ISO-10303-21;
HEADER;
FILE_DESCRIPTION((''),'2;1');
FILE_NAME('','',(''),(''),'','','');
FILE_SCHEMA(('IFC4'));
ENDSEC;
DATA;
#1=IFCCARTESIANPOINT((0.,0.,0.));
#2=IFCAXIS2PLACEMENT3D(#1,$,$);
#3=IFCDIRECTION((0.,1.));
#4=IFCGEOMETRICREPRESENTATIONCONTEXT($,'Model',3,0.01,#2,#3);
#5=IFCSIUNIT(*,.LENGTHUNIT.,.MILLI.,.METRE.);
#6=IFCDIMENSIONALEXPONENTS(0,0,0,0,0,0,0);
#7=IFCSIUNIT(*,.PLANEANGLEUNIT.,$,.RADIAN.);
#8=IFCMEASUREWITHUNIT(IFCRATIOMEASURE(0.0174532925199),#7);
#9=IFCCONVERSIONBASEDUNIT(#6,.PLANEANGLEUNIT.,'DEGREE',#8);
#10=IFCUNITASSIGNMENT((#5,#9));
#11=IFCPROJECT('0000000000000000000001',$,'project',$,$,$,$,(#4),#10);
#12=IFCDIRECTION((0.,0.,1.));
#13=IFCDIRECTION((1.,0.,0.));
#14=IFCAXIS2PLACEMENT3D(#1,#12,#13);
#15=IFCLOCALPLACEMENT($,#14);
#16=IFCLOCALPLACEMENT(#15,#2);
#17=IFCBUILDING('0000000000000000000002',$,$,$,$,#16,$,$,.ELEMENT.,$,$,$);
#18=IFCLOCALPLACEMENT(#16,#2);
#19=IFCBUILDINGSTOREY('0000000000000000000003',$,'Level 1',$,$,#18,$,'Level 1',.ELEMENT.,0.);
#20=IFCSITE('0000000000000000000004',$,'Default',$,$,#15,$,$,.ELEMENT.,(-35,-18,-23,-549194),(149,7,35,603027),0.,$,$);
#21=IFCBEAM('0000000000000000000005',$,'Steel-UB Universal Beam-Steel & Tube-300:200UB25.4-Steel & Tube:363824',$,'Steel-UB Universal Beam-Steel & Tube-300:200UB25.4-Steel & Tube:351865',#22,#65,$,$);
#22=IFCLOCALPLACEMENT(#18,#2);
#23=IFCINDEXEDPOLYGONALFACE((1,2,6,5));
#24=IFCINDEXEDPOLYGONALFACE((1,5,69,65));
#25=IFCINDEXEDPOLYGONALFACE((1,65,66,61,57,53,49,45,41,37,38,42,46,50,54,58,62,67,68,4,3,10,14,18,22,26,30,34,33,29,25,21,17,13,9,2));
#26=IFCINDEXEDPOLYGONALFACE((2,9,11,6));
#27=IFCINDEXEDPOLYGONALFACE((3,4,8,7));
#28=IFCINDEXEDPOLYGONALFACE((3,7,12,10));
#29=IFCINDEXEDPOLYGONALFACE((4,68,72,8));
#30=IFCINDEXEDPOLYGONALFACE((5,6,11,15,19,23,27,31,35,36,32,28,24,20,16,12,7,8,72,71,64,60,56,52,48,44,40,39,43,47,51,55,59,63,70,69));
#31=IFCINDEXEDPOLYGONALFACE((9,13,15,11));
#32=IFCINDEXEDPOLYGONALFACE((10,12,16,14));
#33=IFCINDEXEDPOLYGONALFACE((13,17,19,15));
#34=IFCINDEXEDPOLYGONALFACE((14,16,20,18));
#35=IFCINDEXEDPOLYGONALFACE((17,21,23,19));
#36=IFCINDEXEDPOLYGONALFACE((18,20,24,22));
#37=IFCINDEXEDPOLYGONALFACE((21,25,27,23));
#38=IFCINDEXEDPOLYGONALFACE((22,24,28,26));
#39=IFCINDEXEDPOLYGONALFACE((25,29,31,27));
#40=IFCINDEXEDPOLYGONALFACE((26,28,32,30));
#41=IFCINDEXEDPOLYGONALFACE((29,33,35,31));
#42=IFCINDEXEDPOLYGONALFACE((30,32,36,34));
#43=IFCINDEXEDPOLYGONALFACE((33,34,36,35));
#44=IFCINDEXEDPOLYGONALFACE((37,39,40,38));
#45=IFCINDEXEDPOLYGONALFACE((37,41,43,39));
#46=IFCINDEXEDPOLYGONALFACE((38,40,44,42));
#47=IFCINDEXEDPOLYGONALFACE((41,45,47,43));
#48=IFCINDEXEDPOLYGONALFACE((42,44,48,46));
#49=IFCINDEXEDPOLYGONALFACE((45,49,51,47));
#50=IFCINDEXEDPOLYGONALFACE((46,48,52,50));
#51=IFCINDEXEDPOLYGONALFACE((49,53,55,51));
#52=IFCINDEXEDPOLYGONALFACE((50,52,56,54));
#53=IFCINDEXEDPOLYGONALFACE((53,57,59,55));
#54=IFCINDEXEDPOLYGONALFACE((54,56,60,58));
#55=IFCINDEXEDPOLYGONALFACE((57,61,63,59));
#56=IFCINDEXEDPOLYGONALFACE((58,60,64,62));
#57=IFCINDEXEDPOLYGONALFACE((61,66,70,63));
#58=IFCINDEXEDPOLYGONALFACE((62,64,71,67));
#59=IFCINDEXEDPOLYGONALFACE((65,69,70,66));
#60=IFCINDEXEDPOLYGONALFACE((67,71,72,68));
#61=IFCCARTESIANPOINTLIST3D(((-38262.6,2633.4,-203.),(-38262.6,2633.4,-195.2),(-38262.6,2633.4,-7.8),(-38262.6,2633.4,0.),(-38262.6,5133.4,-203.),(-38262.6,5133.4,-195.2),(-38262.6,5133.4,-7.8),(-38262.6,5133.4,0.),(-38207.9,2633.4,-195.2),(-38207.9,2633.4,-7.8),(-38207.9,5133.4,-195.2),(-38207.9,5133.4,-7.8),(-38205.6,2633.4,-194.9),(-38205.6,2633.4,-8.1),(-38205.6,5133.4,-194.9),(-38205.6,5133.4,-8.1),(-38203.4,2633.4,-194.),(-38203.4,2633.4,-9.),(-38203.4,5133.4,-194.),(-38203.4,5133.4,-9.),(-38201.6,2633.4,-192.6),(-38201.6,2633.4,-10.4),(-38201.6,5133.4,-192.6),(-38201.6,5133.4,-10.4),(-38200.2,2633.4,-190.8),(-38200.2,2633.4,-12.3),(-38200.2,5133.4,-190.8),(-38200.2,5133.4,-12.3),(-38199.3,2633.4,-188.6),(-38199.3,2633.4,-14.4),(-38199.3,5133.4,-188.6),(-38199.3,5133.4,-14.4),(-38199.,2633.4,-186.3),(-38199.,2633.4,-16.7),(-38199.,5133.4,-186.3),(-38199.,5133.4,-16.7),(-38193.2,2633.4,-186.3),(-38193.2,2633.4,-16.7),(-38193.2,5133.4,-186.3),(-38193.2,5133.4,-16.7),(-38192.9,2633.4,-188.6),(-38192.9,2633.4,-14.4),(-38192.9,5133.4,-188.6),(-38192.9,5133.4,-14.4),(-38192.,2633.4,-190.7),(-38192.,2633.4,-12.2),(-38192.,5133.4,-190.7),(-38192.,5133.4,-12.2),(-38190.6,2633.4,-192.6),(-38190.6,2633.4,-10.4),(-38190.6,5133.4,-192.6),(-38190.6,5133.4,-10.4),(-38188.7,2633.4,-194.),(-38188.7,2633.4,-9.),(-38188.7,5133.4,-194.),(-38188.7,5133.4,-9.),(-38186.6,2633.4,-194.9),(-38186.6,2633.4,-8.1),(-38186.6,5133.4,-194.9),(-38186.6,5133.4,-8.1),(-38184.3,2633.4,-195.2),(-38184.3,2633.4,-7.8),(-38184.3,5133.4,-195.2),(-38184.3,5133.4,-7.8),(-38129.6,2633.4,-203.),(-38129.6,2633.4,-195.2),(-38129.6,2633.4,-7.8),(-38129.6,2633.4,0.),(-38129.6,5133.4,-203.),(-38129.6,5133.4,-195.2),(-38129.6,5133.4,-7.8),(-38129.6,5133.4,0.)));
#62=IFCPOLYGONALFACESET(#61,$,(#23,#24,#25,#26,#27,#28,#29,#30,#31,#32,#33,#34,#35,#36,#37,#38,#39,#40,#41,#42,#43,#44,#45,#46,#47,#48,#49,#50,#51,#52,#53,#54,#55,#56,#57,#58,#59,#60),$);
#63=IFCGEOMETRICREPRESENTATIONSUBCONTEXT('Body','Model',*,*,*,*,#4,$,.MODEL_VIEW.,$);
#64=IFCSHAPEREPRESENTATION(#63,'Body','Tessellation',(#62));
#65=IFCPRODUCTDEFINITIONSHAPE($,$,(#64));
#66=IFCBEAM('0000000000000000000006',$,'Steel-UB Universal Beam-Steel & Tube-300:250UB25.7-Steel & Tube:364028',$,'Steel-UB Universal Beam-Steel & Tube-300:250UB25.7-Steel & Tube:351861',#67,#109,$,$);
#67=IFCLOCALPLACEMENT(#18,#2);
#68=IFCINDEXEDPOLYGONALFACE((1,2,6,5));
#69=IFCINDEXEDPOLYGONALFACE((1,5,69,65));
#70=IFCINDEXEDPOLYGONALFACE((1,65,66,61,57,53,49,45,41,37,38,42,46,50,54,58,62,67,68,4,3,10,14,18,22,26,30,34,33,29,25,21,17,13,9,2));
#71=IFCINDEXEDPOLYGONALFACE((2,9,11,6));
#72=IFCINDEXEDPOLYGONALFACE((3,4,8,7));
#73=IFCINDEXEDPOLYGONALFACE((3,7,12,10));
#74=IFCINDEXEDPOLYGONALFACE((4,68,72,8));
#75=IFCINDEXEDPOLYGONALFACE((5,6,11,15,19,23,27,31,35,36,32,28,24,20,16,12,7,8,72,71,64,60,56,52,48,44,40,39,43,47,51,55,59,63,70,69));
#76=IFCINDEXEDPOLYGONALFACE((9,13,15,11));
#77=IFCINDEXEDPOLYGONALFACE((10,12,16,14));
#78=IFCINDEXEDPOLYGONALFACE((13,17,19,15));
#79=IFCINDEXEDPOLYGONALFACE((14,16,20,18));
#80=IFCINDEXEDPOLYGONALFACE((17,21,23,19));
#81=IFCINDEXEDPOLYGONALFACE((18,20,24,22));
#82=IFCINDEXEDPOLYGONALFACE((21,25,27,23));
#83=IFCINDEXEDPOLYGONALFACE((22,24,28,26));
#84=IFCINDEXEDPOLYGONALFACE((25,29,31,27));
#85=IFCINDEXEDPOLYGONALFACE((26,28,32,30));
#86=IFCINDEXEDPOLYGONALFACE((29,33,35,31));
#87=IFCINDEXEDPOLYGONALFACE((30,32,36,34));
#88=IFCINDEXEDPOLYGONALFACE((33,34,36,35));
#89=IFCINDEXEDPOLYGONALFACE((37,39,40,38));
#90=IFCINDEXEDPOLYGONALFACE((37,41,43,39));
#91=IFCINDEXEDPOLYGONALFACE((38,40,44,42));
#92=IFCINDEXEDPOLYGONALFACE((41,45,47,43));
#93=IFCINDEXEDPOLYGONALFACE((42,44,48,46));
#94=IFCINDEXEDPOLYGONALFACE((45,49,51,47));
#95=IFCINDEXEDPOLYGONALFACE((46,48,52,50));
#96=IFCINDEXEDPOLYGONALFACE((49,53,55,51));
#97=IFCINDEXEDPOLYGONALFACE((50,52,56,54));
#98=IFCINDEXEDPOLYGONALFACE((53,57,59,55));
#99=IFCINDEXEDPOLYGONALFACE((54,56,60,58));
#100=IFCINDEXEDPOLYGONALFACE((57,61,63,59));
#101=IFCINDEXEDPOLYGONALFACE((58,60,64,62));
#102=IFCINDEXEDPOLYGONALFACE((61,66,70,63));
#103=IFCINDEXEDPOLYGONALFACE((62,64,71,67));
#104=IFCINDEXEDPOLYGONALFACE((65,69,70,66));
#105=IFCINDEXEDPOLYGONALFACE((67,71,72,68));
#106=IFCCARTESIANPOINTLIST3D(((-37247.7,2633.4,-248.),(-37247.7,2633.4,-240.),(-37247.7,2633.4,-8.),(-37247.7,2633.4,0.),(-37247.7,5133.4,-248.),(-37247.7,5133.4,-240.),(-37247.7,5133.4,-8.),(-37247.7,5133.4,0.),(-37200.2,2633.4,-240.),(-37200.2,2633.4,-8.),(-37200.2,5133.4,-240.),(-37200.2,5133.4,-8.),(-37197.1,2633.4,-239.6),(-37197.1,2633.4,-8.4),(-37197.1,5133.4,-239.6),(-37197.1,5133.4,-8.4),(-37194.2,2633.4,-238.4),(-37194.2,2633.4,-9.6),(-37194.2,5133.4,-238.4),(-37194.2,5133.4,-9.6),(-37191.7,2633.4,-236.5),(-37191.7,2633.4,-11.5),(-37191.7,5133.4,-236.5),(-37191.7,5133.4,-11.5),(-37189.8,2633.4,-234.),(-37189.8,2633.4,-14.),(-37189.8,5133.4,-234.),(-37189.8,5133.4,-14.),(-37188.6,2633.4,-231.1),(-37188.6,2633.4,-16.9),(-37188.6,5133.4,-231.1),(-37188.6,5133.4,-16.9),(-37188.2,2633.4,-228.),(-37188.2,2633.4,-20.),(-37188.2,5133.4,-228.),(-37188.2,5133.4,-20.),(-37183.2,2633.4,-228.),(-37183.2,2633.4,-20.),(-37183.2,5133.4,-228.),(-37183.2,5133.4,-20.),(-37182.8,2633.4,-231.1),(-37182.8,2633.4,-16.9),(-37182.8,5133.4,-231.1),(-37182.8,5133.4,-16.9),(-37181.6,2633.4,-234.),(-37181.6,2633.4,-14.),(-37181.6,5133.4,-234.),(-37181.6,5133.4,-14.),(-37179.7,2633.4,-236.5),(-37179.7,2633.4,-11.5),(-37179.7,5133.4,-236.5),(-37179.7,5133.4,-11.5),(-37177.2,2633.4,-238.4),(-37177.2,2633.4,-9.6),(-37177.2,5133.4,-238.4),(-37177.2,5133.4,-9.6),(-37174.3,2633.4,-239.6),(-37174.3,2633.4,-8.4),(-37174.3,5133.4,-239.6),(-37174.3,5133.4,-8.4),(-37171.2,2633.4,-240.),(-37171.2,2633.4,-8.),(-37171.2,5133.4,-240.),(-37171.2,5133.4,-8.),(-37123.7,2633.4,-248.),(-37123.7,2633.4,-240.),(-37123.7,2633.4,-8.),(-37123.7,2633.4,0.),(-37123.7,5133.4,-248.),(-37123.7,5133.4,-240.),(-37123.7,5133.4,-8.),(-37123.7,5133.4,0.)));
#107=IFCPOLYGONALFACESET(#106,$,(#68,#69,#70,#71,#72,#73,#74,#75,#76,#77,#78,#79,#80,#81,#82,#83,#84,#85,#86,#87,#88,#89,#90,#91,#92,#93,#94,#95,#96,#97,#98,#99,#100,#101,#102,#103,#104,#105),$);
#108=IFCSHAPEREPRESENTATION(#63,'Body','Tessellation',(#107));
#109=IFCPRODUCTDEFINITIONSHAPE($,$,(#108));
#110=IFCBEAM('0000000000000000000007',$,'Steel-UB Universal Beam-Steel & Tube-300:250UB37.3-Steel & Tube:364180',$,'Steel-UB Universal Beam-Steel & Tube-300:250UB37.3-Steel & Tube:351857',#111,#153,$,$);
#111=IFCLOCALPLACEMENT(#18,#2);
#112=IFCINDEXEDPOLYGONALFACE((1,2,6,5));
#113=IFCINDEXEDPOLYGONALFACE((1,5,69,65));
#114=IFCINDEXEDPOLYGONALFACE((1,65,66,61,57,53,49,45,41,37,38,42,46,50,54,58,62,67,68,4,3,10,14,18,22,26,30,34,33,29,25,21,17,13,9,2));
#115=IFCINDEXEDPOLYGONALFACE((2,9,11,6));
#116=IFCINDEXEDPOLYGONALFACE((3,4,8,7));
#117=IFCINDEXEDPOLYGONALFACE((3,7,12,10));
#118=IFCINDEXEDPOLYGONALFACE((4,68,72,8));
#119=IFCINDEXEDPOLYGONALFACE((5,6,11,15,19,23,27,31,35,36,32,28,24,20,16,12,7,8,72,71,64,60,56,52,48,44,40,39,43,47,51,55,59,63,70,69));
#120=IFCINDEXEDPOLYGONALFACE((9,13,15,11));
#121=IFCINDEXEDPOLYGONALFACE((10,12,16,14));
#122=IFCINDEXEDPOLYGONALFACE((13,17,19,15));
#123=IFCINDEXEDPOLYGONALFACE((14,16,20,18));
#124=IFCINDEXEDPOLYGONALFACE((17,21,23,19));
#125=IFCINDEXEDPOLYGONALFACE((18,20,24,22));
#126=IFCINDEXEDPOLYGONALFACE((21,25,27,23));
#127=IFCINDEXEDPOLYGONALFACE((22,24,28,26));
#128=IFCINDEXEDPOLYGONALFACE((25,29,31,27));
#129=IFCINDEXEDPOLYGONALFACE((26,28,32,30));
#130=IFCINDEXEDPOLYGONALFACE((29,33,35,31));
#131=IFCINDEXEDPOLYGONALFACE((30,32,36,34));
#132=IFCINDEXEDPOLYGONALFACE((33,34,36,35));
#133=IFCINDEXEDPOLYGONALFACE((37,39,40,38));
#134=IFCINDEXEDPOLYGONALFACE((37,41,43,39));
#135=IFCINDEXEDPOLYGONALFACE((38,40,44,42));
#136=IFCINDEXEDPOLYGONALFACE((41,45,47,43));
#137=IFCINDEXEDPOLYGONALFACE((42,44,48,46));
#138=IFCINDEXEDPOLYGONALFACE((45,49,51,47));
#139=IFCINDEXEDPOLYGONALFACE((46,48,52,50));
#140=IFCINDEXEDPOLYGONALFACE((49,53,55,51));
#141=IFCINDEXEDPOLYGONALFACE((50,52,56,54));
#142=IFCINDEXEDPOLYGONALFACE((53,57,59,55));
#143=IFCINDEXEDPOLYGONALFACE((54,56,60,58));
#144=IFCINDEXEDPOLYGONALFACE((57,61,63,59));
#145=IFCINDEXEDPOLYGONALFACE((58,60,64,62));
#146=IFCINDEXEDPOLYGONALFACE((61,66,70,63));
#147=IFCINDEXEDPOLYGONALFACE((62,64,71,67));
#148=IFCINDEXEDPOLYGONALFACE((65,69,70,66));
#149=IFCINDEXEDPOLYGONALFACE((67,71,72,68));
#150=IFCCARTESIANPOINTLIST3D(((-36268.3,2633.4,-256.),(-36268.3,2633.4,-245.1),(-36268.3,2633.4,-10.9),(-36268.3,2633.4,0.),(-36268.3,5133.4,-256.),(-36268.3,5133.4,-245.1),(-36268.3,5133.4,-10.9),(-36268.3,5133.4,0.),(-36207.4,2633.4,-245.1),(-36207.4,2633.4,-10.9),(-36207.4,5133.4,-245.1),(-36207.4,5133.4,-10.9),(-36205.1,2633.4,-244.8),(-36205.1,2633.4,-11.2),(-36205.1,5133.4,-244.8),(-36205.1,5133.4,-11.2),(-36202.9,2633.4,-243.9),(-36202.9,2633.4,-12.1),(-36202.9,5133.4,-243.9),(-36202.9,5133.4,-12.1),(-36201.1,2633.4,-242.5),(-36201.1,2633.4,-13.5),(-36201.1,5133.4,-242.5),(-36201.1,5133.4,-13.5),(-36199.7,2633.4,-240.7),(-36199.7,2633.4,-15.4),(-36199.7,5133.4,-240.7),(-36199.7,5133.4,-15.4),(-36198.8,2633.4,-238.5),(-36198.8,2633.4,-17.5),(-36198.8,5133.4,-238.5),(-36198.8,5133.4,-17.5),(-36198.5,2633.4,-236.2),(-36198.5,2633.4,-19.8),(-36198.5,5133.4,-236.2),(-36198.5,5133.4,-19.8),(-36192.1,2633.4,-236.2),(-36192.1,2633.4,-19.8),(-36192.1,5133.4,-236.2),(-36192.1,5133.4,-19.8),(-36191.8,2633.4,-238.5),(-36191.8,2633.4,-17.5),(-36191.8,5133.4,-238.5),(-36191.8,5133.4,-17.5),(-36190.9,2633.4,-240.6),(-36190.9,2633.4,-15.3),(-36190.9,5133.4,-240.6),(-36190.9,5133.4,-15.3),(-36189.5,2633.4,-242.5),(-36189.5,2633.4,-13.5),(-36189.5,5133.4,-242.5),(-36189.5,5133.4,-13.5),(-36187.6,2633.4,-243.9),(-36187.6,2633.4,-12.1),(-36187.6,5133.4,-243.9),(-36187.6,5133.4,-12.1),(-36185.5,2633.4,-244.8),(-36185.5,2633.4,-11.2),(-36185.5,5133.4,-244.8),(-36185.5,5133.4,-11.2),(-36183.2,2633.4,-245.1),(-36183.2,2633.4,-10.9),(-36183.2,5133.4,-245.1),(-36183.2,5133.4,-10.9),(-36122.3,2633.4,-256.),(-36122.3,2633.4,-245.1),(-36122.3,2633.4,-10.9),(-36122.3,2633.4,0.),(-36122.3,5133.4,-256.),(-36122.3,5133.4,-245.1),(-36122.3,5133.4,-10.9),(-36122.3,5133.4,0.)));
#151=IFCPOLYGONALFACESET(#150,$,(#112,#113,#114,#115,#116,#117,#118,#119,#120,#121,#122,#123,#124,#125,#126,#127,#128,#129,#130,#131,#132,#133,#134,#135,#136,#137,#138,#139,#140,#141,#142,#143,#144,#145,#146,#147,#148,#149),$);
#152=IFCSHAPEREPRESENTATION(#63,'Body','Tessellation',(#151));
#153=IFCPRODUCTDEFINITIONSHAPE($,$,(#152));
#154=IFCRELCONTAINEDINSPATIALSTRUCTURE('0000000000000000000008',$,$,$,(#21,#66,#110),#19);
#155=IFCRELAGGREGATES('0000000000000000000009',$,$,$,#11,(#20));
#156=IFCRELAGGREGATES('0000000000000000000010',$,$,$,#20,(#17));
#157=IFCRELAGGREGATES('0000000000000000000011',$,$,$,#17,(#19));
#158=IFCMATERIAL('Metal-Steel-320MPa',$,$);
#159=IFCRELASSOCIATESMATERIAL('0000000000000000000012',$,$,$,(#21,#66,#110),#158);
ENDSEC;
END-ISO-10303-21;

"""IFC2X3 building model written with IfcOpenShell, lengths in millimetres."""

from ifc_helpers import new_model, entity, si_unit, converted_unit, direction, frame, frame_2d, origin, origin_with_axes, place, context, subcontext, project, spatial, polyline, circle_curve, parameter, trimmed, segment, composite_curve, outline, extrude, material, element, save


model = new_model("IFC2X3")

# Units and contexts
model_context = context("Model", 3, precision=0.01, world=origin(), true_north=direction((0.0, 1.0)))
body_context = subcontext(model_context, "Body", "Model", "MODEL_VIEW")
ifc_project = project(units=[si_unit("LENGTHUNIT", "METRE", prefix="MILLI"), converted_unit("PLANEANGLEUNIT", "DEGREE", entity("IfcRatioMeasure", 0.0174532925199), si_unit("PLANEANGLEUNIT", "RADIAN"), dimensions=[0, 0, 0, 0, 0, 0, 0])], contexts=[model_context])

# Site, building, storey
site_placement = place(None, origin_with_axes())
site = spatial("IfcSite", under=ifc_project, at=site_placement, Name="Default", CompositionType="ELEMENT", RefLatitude=(-35, -18, -23, -549194), RefLongitude=(149, 7, 35, 603027), RefElevation=0.0)
building_placement = place(site_placement, origin())
building = spatial("IfcBuilding", under=site, at=building_placement, CompositionType="ELEMENT")
storey_placement = place(building_placement, origin())
storey = spatial("IfcBuildingStorey", under=building, at=storey_placement, Name="Level 1", LongName="Level 1", CompositionType="ELEMENT", Elevation=0.0)

# Beams
ifc_material = material(Name="Metal-Steel-320MPa")
beam_1_placement = place(storey_placement, frame((-38196.1, 5133.4, 0.0), z_axis=(0.0, 0.0, 1.0), x_axis=(0.0, -1.0, 0.0)))
element("IfcBeam", 1, at=beam_1_placement, inside=storey, material=ifc_material, Name="Steel-UB Universal Beam-Steel & Tube-300:200UB25.4-Steel & Tube:363824", ObjectType="Steel-UB Universal Beam-Steel & Tube-300:200UB25.4-Steel & Tube:351865", context=body_context, shape_type="SweptSolid", body=[
    extrude(outline(composite_curve([segment(polyline([(93.7, -66.5), (101.5, -66.5)]), True, "CONTINUOUS"), segment(polyline([(101.5, -66.5), (101.5, 66.5)]), True, "CONTINUOUS"), segment(polyline([(101.5, 66.5), (93.7, 66.5)]), True, "CONTINUOUS"), segment(polyline([(93.7, 66.5), (93.7, 11.8)]), True, "CONTINUOUS"), segment(trimmed(circle_curve(frame_2d((84.8, 11.8), x_axis=(1.0, 0.0)), 8.9), [parameter(270.0)], [parameter(0.0)], True, "PARAMETER"), False, "CONTINUOUS"), segment(polyline([(84.8, 2.9), (-84.8, 2.9)]), True, "CONTINUOUS"), segment(trimmed(circle_curve(frame_2d((-84.8, 11.8), x_axis=(0.0, -1.0)), 8.9), [parameter(270.0)], [parameter(0.0)], True, "PARAMETER"), False, "CONTINUOUS"), segment(polyline([(-93.7, 11.8), (-93.7, 66.5)]), True, "CONTINUOUS"), segment(polyline([(-93.7, 66.5), (-101.5, 66.5)]), True, "CONTINUOUS"), segment(polyline([(-101.5, 66.5), (-101.5, -66.5)]), True, "CONTINUOUS"), segment(polyline([(-101.5, -66.5), (-93.7, -66.5)]), True, "CONTINUOUS"), segment(polyline([(-93.7, -66.5), (-93.7, -11.8)]), True, "CONTINUOUS"), segment(trimmed(circle_curve(frame_2d((-84.8, -11.8), x_axis=(-1.0, 0.0)), 8.9), [parameter(270.0)], [parameter(0.0)], True, "PARAMETER"), False, "CONTINUOUS"), segment(polyline([(-84.8, -2.9), (84.8, -2.9)]), True, "CONTINUOUS"), segment(trimmed(circle_curve(frame_2d((84.8, -11.8), x_axis=(0.0, 1.0)), 8.9), [parameter(270.0)], [parameter(0.0)], True, "PARAMETER"), False, "CONTINUOUS"), segment(polyline([(93.7, -11.8), (93.7, -66.5)]), True, "CONTINUOUS")], self_intersect=False)), frame((0.0, 0.0, -101.5), z_axis=(1.0, 0.0, 0.0), x_axis=(0.0, 0.0, -1.0)), (0.0, 0.0, 1.0), 2500.0),
])
beam_2_placement = place(storey_placement, frame((-37185.7, 5133.4, 0.0), z_axis=(0.0, 0.0, 1.0), x_axis=(0.0, -1.0, 0.0)))
element("IfcBeam", 2, at=beam_2_placement, inside=storey, material=ifc_material, Name="Steel-UB Universal Beam-Steel & Tube-300:250UB25.7-Steel & Tube:364028", ObjectType="Steel-UB Universal Beam-Steel & Tube-300:250UB25.7-Steel & Tube:351861", context=body_context, shape_type="SweptSolid", body=[
    extrude(outline(composite_curve([segment(polyline([(116.0, -62.0), (124.0, -62.0)]), True, "CONTINUOUS"), segment(polyline([(124.0, -62.0), (124.0, 62.0)]), True, "CONTINUOUS"), segment(polyline([(124.0, 62.0), (116.0, 62.0)]), True, "CONTINUOUS"), segment(polyline([(116.0, 62.0), (116.0, 14.5)]), True, "CONTINUOUS"), segment(trimmed(circle_curve(frame_2d((104.0, 14.5), x_axis=(1.0, 0.0)), 12.0), [parameter(270.0)], [parameter(0.0)], True, "PARAMETER"), False, "CONTINUOUS"), segment(polyline([(104.0, 2.5), (-104.0, 2.5)]), True, "CONTINUOUS"), segment(trimmed(circle_curve(frame_2d((-104.0, 14.5), x_axis=(0.0, -1.0)), 12.0), [parameter(270.0)], [parameter(0.0)], True, "PARAMETER"), False, "CONTINUOUS"), segment(polyline([(-116.0, 14.5), (-116.0, 62.0)]), True, "CONTINUOUS"), segment(polyline([(-116.0, 62.0), (-124.0, 62.0)]), True, "CONTINUOUS"), segment(polyline([(-124.0, 62.0), (-124.0, -62.0)]), True, "CONTINUOUS"), segment(polyline([(-124.0, -62.0), (-116.0, -62.0)]), True, "CONTINUOUS"), segment(polyline([(-116.0, -62.0), (-116.0, -14.5)]), True, "CONTINUOUS"), segment(trimmed(circle_curve(frame_2d((-104.0, -14.5), x_axis=(-1.0, 0.0)), 12.0), [parameter(270.0)], [parameter(0.0)], True, "PARAMETER"), False, "CONTINUOUS"), segment(polyline([(-104.0, -2.5), (104.0, -2.5)]), True, "CONTINUOUS"), segment(trimmed(circle_curve(frame_2d((104.0, -14.5), x_axis=(0.0, 1.0)), 12.0), [parameter(270.0)], [parameter(0.0)], True, "PARAMETER"), False, "CONTINUOUS"), segment(polyline([(116.0, -14.5), (116.0, -62.0)]), True, "CONTINUOUS")], self_intersect=False)), frame((0.0, 0.0, -124.0), z_axis=(1.0, 0.0, 0.0), x_axis=(0.0, 0.0, -1.0)), (0.0, 0.0, 1.0), 2500.0),
])
beam_3_placement = place(storey_placement, frame((-36195.3, 5133.4, 0.0), z_axis=(0.0, 0.0, 1.0), x_axis=(0.0, -1.0, 0.0)))
element("IfcBeam", 3, at=beam_3_placement, inside=storey, material=ifc_material, Name="Steel-UB Universal Beam-Steel & Tube-300:250UB37.3-Steel & Tube:364180", ObjectType="Steel-UB Universal Beam-Steel & Tube-300:250UB37.3-Steel & Tube:351857", context=body_context, shape_type="SweptSolid", body=[
    extrude(outline(composite_curve([segment(polyline([(117.1, -73.0), (128.0, -73.0)]), True, "CONTINUOUS"), segment(polyline([(128.0, -73.0), (128.0, 73.0)]), True, "CONTINUOUS"), segment(polyline([(128.0, 73.0), (117.1, 73.0)]), True, "CONTINUOUS"), segment(polyline([(117.1, 73.0), (117.1, 12.1)]), True, "CONTINUOUS"), segment(trimmed(circle_curve(frame_2d((108.2, 12.1), x_axis=(1.0, 0.0)), 8.9), [parameter(270.0)], [parameter(0.0)], True, "PARAMETER"), False, "CONTINUOUS"), segment(polyline([(108.2, 3.2), (-108.2, 3.2)]), True, "CONTINUOUS"), segment(trimmed(circle_curve(frame_2d((-108.2, 12.1), x_axis=(0.0, -1.0)), 8.9), [parameter(270.0)], [parameter(0.0)], True, "PARAMETER"), False, "CONTINUOUS"), segment(polyline([(-117.1, 12.1), (-117.1, 73.0)]), True, "CONTINUOUS"), segment(polyline([(-117.1, 73.0), (-128.0, 73.0)]), True, "CONTINUOUS"), segment(polyline([(-128.0, 73.0), (-128.0, -73.0)]), True, "CONTINUOUS"), segment(polyline([(-128.0, -73.0), (-117.1, -73.0)]), True, "CONTINUOUS"), segment(polyline([(-117.1, -73.0), (-117.1, -12.1)]), True, "CONTINUOUS"), segment(trimmed(circle_curve(frame_2d((-108.2, -12.1), x_axis=(-1.0, 0.0)), 8.9), [parameter(270.0)], [parameter(0.0)], True, "PARAMETER"), False, "CONTINUOUS"), segment(polyline([(-108.2, -3.2), (108.2, -3.2)]), True, "CONTINUOUS"), segment(trimmed(circle_curve(frame_2d((108.2, -12.1), x_axis=(0.0, 1.0)), 8.9), [parameter(270.0)], [parameter(0.0)], True, "PARAMETER"), False, "CONTINUOUS"), segment(polyline([(117.1, -12.1), (117.1, -73.0)]), True, "CONTINUOUS")], self_intersect=False)), frame((0.0, 0.0, -128.0), z_axis=(1.0, 0.0, 0.0), x_axis=(0.0, 0.0, -1.0)), (0.0, 0.0, 1.0), 2500.0),
])

save(model, "model.ifc")
